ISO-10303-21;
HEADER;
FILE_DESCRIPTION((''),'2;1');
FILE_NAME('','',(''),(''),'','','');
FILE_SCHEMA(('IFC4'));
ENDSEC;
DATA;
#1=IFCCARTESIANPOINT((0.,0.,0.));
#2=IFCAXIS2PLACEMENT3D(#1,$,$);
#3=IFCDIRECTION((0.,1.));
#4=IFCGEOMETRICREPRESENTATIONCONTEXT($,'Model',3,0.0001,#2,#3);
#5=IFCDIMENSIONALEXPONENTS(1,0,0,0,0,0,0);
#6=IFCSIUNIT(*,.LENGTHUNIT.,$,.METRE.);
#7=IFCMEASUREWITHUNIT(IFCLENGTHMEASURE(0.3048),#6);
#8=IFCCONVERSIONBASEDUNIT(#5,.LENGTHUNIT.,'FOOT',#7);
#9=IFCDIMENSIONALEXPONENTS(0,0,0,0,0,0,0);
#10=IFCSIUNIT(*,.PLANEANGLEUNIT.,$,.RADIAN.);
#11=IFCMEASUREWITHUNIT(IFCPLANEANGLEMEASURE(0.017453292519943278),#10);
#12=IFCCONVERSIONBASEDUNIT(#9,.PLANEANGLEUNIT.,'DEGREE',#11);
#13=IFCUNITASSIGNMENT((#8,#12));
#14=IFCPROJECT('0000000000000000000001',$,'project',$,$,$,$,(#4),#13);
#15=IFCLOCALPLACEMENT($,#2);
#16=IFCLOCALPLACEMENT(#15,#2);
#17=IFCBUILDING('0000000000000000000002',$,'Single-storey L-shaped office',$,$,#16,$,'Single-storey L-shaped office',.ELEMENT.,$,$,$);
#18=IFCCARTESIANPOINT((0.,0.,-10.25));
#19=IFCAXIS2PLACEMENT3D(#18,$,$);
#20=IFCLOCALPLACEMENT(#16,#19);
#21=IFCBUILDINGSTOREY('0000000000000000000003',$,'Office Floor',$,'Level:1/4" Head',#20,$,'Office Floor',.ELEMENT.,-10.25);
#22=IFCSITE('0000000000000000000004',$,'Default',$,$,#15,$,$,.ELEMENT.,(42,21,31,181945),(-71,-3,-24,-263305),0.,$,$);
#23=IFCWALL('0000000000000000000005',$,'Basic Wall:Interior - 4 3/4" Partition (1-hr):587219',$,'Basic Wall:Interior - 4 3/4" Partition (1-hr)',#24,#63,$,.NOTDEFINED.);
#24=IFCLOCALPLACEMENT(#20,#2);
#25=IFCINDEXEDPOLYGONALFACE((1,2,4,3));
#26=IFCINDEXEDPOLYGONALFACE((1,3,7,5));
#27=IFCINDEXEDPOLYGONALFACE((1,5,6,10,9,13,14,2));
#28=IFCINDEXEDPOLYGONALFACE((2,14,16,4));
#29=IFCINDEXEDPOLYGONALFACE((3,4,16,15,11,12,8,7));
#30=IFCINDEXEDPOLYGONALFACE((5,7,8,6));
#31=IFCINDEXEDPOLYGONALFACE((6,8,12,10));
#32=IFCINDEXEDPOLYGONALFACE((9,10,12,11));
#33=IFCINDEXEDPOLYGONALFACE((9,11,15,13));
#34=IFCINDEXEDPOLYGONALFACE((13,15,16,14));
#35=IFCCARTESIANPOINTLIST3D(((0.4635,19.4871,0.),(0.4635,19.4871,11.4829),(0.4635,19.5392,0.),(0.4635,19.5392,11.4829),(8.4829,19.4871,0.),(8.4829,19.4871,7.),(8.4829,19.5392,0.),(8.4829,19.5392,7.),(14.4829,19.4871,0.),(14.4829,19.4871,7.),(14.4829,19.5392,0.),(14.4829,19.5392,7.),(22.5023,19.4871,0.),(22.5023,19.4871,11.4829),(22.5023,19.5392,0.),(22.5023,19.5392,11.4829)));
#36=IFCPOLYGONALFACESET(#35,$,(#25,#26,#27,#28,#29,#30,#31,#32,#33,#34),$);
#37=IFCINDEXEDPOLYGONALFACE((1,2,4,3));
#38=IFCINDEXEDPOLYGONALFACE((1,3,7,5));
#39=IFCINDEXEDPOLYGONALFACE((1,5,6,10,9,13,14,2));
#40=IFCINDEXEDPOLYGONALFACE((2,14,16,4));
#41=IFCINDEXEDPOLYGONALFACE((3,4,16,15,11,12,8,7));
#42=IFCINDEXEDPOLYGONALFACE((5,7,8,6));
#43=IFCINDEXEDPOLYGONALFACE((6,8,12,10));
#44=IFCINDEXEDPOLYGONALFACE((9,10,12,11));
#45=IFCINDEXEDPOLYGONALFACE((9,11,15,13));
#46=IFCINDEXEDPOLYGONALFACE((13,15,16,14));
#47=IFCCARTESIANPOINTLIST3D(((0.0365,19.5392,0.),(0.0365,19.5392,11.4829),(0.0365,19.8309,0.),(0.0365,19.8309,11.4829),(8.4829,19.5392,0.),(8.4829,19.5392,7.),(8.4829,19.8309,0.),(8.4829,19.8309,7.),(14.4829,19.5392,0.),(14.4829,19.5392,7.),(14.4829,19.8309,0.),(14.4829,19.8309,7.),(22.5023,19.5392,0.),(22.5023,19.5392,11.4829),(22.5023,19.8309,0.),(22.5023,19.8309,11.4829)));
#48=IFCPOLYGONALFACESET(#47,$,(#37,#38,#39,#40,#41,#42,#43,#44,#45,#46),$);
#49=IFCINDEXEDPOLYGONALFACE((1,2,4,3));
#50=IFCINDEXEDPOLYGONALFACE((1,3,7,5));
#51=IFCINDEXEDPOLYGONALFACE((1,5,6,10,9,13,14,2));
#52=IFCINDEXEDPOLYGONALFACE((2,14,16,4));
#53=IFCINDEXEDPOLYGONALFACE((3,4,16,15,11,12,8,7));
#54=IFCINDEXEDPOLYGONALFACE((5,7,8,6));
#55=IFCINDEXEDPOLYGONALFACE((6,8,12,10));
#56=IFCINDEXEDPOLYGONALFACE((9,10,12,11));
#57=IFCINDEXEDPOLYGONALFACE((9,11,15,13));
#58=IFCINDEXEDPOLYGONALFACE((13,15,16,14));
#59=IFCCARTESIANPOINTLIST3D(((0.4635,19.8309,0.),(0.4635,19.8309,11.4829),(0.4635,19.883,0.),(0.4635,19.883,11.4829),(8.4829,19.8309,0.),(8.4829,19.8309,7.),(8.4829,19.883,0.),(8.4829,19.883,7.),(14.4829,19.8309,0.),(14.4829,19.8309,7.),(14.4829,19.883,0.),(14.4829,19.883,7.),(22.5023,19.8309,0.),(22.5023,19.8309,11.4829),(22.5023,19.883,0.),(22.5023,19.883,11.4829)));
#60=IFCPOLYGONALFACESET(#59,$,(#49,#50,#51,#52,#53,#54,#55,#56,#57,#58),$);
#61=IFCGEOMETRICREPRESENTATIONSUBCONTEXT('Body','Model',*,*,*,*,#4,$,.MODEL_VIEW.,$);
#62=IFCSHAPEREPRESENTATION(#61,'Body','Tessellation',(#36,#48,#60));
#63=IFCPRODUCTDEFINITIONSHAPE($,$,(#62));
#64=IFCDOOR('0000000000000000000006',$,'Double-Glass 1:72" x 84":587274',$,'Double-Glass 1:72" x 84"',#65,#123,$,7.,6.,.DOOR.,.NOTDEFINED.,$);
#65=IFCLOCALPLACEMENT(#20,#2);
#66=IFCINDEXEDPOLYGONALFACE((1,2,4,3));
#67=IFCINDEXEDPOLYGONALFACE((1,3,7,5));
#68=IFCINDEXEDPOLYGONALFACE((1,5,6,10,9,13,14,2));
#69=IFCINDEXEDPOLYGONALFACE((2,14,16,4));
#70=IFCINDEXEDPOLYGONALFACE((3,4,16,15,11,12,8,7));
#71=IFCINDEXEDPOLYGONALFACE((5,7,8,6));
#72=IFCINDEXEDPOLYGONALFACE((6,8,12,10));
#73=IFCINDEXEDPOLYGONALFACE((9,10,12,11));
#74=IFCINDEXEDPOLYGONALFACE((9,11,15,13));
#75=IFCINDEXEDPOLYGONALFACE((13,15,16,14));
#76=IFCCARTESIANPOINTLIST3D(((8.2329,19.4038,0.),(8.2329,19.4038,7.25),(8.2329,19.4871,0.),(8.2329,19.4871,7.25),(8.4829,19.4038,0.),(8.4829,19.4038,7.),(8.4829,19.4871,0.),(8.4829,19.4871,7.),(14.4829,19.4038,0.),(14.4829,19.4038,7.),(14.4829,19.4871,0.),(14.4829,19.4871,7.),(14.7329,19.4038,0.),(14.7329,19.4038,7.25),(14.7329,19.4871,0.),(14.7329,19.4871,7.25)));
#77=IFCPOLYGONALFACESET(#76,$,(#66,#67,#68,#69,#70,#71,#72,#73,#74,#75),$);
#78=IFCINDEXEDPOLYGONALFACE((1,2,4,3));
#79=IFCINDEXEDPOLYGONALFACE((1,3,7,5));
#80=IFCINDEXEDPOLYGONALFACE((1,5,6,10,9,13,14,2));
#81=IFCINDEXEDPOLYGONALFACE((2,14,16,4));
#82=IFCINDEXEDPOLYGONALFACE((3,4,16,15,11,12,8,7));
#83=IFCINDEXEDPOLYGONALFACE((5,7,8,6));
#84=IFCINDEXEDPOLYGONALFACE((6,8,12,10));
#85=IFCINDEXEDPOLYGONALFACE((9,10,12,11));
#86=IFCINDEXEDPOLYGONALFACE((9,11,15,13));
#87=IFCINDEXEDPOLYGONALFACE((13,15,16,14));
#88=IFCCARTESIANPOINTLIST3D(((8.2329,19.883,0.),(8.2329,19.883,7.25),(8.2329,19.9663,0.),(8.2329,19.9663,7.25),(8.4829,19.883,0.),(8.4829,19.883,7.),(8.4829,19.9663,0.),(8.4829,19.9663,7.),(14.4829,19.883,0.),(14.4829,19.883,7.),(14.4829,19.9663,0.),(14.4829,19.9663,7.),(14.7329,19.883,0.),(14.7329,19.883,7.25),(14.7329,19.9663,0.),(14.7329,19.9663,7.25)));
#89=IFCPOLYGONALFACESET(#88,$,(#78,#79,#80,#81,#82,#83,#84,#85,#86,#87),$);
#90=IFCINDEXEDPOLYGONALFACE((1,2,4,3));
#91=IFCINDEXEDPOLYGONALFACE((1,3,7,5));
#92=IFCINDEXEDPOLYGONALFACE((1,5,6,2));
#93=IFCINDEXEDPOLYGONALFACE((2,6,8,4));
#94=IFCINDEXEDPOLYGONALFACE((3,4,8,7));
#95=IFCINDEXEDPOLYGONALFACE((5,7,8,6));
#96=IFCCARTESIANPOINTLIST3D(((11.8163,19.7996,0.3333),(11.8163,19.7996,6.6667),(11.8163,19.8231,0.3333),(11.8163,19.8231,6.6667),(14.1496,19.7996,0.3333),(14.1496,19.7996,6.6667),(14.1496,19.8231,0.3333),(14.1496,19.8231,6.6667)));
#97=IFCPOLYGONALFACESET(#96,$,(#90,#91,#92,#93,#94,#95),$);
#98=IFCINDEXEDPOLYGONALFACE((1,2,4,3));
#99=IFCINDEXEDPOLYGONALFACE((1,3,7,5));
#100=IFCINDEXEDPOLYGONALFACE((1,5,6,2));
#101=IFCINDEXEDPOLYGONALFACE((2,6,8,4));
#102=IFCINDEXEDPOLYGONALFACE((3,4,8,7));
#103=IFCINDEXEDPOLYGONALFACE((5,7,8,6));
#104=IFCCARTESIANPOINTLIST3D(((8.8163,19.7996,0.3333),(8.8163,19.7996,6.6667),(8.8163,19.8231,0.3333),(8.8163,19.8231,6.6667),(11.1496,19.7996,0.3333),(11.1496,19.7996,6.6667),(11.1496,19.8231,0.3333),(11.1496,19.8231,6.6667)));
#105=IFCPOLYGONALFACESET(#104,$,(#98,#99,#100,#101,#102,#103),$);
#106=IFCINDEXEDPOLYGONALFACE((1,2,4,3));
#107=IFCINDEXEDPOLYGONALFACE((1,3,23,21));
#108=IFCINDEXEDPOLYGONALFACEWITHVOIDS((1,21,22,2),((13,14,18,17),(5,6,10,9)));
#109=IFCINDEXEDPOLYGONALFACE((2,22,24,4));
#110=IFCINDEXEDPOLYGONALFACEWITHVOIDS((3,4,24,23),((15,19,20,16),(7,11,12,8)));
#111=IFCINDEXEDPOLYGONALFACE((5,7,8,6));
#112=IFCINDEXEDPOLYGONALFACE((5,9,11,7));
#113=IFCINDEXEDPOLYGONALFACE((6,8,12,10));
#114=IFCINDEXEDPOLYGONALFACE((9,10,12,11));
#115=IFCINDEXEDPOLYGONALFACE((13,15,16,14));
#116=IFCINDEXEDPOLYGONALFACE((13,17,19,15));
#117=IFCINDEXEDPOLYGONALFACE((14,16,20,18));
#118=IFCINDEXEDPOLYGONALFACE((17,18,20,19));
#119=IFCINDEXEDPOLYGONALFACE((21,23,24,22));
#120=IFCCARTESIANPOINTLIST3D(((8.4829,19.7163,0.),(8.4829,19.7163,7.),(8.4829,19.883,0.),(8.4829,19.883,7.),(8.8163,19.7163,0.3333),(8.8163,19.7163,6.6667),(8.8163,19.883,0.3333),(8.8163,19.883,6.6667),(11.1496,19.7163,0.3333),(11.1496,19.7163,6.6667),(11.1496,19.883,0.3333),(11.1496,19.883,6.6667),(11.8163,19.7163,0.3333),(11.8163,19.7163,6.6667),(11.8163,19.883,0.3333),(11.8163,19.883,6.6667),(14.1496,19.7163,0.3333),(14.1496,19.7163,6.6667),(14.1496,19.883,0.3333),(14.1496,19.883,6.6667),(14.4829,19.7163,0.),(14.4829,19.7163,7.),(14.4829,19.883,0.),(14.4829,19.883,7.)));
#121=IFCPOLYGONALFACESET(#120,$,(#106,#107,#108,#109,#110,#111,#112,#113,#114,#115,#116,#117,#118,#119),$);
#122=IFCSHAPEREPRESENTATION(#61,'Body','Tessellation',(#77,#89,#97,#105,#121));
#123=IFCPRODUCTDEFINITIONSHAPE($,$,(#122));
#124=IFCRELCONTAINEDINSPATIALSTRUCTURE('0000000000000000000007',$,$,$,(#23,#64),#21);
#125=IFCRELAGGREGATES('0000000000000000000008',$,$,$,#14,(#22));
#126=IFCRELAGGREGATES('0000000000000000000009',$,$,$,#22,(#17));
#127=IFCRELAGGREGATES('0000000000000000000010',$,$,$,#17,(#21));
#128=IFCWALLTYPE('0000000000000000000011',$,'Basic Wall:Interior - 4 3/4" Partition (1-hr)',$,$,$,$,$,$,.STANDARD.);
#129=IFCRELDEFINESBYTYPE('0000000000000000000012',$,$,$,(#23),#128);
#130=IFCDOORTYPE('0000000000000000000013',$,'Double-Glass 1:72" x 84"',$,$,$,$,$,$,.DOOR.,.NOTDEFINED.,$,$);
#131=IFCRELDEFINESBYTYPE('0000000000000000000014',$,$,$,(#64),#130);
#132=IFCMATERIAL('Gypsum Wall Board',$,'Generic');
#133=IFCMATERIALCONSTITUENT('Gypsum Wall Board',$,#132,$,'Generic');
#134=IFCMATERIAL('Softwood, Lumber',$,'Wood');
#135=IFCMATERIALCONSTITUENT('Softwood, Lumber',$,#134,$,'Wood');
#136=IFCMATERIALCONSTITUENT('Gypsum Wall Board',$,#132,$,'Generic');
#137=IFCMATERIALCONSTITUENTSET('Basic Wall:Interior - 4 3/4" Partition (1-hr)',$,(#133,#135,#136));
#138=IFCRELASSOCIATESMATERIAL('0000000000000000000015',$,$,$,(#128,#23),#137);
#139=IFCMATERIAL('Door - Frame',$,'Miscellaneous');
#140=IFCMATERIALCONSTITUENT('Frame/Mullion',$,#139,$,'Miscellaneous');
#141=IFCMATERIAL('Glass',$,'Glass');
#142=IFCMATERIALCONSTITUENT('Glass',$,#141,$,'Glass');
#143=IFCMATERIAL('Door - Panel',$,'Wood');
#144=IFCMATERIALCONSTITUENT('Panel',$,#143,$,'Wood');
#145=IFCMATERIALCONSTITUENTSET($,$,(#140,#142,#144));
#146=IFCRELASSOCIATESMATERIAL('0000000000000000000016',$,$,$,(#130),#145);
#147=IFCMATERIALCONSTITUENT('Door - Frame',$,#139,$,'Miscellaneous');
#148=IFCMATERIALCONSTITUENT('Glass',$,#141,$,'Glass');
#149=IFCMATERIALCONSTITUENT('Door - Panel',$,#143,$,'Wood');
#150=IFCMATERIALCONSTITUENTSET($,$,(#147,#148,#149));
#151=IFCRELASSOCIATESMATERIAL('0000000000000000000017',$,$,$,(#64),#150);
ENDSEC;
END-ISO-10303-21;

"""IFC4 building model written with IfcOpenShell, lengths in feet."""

from ifc_helpers import new_model, entity, si_unit, converted_unit, direction, frame, origin, place, context, subcontext, project, spatial, indexed_curve, outline, extrude, source, transform, mapped, material, constituent, constituent_set, type_object, type_shapes, element, fill, save


model = new_model("IFC4")

# Units and contexts
model_context = context("Model", 3, precision=0.0001, world=origin(), true_north=direction((0.0, 1.0)))
body_context = subcontext(model_context, "Body", "Model", "MODEL_VIEW")
ifc_project = project(units=[converted_unit("LENGTHUNIT", "FOOT", entity("IfcLengthMeasure", 0.3048), si_unit("LENGTHUNIT", "METRE"), dimensions=[1, 0, 0, 0, 0, 0, 0]), converted_unit("PLANEANGLEUNIT", "DEGREE", entity("IfcPlaneAngleMeasure", 0.017453292519943278), si_unit("PLANEANGLEUNIT", "RADIAN"), dimensions=[0, 0, 0, 0, 0, 0, 0])], contexts=[model_context])

# Site, building, storey
site_placement = place(None, origin())
site = spatial("IfcSite", under=ifc_project, at=site_placement, Name="Default", CompositionType="ELEMENT", RefLatitude=(42, 21, 31, 181945), RefLongitude=(-71, -3, -24, -263305), RefElevation=0.0)
building_placement = place(site_placement, origin())
building = spatial("IfcBuilding", under=site, at=building_placement, Name="Single-storey L-shaped office", LongName="Single-storey L-shaped office", CompositionType="ELEMENT")
storey_placement = place(building_placement, frame((0.0, 0.0, -10.25)))
storey = spatial("IfcBuildingStorey", under=building, at=storey_placement, Name="Office Floor", ObjectType="Level:1/4\" Head", LongName="Office Floor", CompositionType="ELEMENT", Elevation=-10.25)

# Shared definitions
ifc_material_1 = material(Name="Softwood, Lumber", Category="Wood")
ifc_material_2 = material(Name="Gypsum Wall Board", Category="Generic")
ifc_material_3 = material(Name="Door - Frame", Category="Miscellaneous")
ifc_material_4 = material(Name="Glass", Category="Glass")
ifc_material_5 = material(Name="Door - Panel", Category="Wood")

# Wall, opening, door
ifc_constituent_1 = constituent(ifc_material_2, Name="Gypsum Wall Board", Category="Generic")
ifc_constituent_2 = constituent(ifc_material_1, Name="Softwood, Lumber", Category="Wood")
ifc_constituent_3 = constituent(ifc_material_2, Name="Gypsum Wall Board", Category="Generic")
ifc_constituent_set_1 = constituent_set(constituents=[ifc_constituent_1, ifc_constituent_2, ifc_constituent_3], Name="Basic Wall:Interior - 4 3/4\" Partition (1-hr)")
wall_type_1 = type_object("IfcWallType", Name="Basic Wall:Interior - 4 3/4\" Partition (1-hr)", PredefinedType="STANDARD", material=ifc_constituent_set_1)
ifc_constituent_4 = constituent(ifc_material_3, Name="Frame/Mullion", Category="Miscellaneous")
ifc_constituent_5 = constituent(ifc_material_4, Name="Glass", Category="Glass")
ifc_constituent_6 = constituent(ifc_material_5, Name="Panel", Category="Wood")
ifc_constituent_set_2 = constituent_set(constituents=[ifc_constituent_4, ifc_constituent_5, ifc_constituent_6])
door_type_1 = type_object("IfcDoorType", Name="Double-Glass 1:72\" x 84\"", OperationType="NOTDEFINED", PredefinedType="DOOR", material=ifc_constituent_set_2)
shared_shape_1 = source(origin(), body_context, "Body", "SweptSolid", [
    extrude(outline(indexed_curve([(-3.25, -3.5625), (-3.0, -3.5625), (-3.0, 3.4375), (3.0, 3.4375), (3.0, -3.5625), (3.25, -3.5625), (3.25, 3.6875), (-3.25, 3.6875), (-3.25, -3.5625)], self_intersect=False)), frame((3.0, -0.0833, 3.5625), z_axis=(0.0, 1.0, 0.0), x_axis=(-1.0, 0.0, 0.0)), (0.0, 0.0, 1.0), 0.0833),
    extrude(outline(indexed_curve([(-3.0, -3.4375), (-3.0, 3.5625), (-3.25, 3.5625), (-3.25, -3.6875), (3.25, -3.6875), (3.25, 3.5625), (3.0, 3.5625), (3.0, -3.4375), (-3.0, -3.4375)], self_intersect=False)), frame((3.0, 0.3958, 3.5625), z_axis=(0.0, -1.0, 0.0), x_axis=(-1.0, 0.0, 0.0)), (0.0, 0.0, -1.0), 0.0833),
    extrude(outline(indexed_curve([(-0.0117, -1.1667), (0.0117, -1.1667), (0.0117, 1.1667), (-0.0117, 1.1667), (-0.0117, -1.1667)], self_intersect=False)), frame((4.5, 0.3242, 0.3333), z_axis=(0.0, 0.0, 1.0), x_axis=(0.0, 1.0, 0.0)), (0.0, 0.0, 1.0), 6.3333),
    extrude(outline(indexed_curve([(-0.0117, -1.1667), (0.0117, -1.1667), (0.0117, 1.1667), (-0.0117, 1.1667), (-0.0117, -1.1667)], self_intersect=False)), frame((1.5, 0.3242, 0.3333), z_axis=(0.0, 0.0, 1.0), x_axis=(0.0, 1.0, 0.0)), (0.0, 0.0, 1.0), 6.3333),
    extrude(outline(indexed_curve([(-3.5, -3.0), (3.5, -3.0), (3.5, 3.0), (-3.5, 3.0), (-3.5, -3.0)], self_intersect=False), holes=[indexed_curve([(-3.1667, 0.3333), (-3.1667, 2.6667), (3.1667, 2.6667), (3.1667, 0.3333), (-3.1667, 0.3333)], self_intersect=False), indexed_curve([(-3.1667, -2.6667), (-3.1667, -0.3333), (3.1667, -0.3333), (3.1667, -2.6667), (-3.1667, -2.6667)], self_intersect=False)]), frame((3.0, 0.2292, 3.5), z_axis=(0.0, 1.0, 0.0), x_axis=(0.0, 0.0, -1.0)), (0.0, 0.0, 1.0), 0.1667),
])
type_shapes(door_type_1, [shared_shape_1])
wall_1_placement = place(storey_placement, frame((0.4635, 19.685, 0.0)))
wall_1 = element("IfcWall", 1, at=wall_1_placement, inside=storey, type_object=wall_type_1, material=ifc_constituent_set_1, Name="Basic Wall:Interior - 4 3/4\" Partition (1-hr):587219", ObjectType="Basic Wall:Interior - 4 3/4\" Partition (1-hr)", PredefinedType="NOTDEFINED", context=body_context, shape_type="SweptSolid", body=[
    extrude(outline(indexed_curve([(-3.0, -2.3793), (-3.0, 4.6207), (-11.0194, 4.6207), (-11.0194, -6.8622), (11.0194, -6.8622), (11.0194, 4.6207), (3.0, 4.6207), (3.0, -2.3793), (-3.0, -2.3793)], self_intersect=False)), frame((11.0194, -0.1979, 4.6207), z_axis=(0.0, -1.0, 0.0), x_axis=(-1.0, 0.0, 0.0)), (0.0, 0.0, -1.0), 0.0521),
    extrude(outline(indexed_curve([(-4.6207, -11.3397), (6.8622, -11.3397), (6.8622, 11.1262), (-4.6207, 11.1262), (-4.6207, 3.1068), (2.3793, 3.1068), (2.3793, -2.8932), (-4.6207, -2.8932), (-4.6207, -11.3397)], self_intersect=False)), frame((10.9126, -0.1458, 4.6207), z_axis=(0.0, 1.0, 0.0), x_axis=(0.0, 0.0, 1.0)), (0.0, 0.0, 1.0), 0.2917),
    extrude(outline(indexed_curve([(-4.6207, -11.0194), (6.8622, -11.0194), (6.8622, 11.0194), (-4.6207, 11.0194), (-4.6207, 3.0), (2.3793, 3.0), (2.3793, -3.0), (-4.6207, -3.0), (-4.6207, -11.0194)], self_intersect=False)), frame((11.0194, 0.1458, 4.6207), z_axis=(0.0, 1.0, 0.0), x_axis=(0.0, 0.0, 1.0)), (0.0, 0.0, 1.0), 0.0521),
])
opening_1_placement = place(wall_1_placement, frame((8.0194, -0.1979, 0.0)))
opening_1 = element("IfcOpeningElement", 2, at=opening_1_placement, cuts=wall_1, PredefinedType="OPENING", context=body_context, shape_type="SweptSolid", body=[
    extrude(outline(indexed_curve([(0.0, 0.0), (7.0, 0.0), (7.0, 6.0), (0.0, 6.0), (0.0, 0.0)], self_intersect=False)), frame((0.0, 0.0, 0.0), z_axis=(0.0, 1.0, 0.0), x_axis=(0.0, 0.0, 1.0)), (0.0, 0.0, 1.0), 0.3958),
])
ifc_constituent_7 = constituent(ifc_material_3, Name="Door - Frame", Category="Miscellaneous")
ifc_constituent_8 = constituent(ifc_material_4, Name="Glass", Category="Glass")
ifc_constituent_9 = constituent(ifc_material_5, Name="Door - Panel", Category="Wood")
ifc_constituent_set_3 = constituent_set(constituents=[ifc_constituent_7, ifc_constituent_8, ifc_constituent_9])
door_1_placement = place(opening_1_placement, origin())
door_1 = element("IfcDoor", 3, at=door_1_placement, inside=storey, type_object=door_type_1, material=ifc_constituent_set_3, Name="Double-Glass 1:72\" x 84\":587274", ObjectType="Double-Glass 1:72\" x 84\"", OperationType="NOTDEFINED", OverallHeight=7.0, OverallWidth=6.0, PredefinedType="DOOR", context=body_context, shape_type="MappedRepresentation", body=[
    mapped(shared_shape_1, transform((0.0, 0.0, 0.0), scale=1.0)),
])
fill(opening_1, door_1)

save(model, "model.ifc")
